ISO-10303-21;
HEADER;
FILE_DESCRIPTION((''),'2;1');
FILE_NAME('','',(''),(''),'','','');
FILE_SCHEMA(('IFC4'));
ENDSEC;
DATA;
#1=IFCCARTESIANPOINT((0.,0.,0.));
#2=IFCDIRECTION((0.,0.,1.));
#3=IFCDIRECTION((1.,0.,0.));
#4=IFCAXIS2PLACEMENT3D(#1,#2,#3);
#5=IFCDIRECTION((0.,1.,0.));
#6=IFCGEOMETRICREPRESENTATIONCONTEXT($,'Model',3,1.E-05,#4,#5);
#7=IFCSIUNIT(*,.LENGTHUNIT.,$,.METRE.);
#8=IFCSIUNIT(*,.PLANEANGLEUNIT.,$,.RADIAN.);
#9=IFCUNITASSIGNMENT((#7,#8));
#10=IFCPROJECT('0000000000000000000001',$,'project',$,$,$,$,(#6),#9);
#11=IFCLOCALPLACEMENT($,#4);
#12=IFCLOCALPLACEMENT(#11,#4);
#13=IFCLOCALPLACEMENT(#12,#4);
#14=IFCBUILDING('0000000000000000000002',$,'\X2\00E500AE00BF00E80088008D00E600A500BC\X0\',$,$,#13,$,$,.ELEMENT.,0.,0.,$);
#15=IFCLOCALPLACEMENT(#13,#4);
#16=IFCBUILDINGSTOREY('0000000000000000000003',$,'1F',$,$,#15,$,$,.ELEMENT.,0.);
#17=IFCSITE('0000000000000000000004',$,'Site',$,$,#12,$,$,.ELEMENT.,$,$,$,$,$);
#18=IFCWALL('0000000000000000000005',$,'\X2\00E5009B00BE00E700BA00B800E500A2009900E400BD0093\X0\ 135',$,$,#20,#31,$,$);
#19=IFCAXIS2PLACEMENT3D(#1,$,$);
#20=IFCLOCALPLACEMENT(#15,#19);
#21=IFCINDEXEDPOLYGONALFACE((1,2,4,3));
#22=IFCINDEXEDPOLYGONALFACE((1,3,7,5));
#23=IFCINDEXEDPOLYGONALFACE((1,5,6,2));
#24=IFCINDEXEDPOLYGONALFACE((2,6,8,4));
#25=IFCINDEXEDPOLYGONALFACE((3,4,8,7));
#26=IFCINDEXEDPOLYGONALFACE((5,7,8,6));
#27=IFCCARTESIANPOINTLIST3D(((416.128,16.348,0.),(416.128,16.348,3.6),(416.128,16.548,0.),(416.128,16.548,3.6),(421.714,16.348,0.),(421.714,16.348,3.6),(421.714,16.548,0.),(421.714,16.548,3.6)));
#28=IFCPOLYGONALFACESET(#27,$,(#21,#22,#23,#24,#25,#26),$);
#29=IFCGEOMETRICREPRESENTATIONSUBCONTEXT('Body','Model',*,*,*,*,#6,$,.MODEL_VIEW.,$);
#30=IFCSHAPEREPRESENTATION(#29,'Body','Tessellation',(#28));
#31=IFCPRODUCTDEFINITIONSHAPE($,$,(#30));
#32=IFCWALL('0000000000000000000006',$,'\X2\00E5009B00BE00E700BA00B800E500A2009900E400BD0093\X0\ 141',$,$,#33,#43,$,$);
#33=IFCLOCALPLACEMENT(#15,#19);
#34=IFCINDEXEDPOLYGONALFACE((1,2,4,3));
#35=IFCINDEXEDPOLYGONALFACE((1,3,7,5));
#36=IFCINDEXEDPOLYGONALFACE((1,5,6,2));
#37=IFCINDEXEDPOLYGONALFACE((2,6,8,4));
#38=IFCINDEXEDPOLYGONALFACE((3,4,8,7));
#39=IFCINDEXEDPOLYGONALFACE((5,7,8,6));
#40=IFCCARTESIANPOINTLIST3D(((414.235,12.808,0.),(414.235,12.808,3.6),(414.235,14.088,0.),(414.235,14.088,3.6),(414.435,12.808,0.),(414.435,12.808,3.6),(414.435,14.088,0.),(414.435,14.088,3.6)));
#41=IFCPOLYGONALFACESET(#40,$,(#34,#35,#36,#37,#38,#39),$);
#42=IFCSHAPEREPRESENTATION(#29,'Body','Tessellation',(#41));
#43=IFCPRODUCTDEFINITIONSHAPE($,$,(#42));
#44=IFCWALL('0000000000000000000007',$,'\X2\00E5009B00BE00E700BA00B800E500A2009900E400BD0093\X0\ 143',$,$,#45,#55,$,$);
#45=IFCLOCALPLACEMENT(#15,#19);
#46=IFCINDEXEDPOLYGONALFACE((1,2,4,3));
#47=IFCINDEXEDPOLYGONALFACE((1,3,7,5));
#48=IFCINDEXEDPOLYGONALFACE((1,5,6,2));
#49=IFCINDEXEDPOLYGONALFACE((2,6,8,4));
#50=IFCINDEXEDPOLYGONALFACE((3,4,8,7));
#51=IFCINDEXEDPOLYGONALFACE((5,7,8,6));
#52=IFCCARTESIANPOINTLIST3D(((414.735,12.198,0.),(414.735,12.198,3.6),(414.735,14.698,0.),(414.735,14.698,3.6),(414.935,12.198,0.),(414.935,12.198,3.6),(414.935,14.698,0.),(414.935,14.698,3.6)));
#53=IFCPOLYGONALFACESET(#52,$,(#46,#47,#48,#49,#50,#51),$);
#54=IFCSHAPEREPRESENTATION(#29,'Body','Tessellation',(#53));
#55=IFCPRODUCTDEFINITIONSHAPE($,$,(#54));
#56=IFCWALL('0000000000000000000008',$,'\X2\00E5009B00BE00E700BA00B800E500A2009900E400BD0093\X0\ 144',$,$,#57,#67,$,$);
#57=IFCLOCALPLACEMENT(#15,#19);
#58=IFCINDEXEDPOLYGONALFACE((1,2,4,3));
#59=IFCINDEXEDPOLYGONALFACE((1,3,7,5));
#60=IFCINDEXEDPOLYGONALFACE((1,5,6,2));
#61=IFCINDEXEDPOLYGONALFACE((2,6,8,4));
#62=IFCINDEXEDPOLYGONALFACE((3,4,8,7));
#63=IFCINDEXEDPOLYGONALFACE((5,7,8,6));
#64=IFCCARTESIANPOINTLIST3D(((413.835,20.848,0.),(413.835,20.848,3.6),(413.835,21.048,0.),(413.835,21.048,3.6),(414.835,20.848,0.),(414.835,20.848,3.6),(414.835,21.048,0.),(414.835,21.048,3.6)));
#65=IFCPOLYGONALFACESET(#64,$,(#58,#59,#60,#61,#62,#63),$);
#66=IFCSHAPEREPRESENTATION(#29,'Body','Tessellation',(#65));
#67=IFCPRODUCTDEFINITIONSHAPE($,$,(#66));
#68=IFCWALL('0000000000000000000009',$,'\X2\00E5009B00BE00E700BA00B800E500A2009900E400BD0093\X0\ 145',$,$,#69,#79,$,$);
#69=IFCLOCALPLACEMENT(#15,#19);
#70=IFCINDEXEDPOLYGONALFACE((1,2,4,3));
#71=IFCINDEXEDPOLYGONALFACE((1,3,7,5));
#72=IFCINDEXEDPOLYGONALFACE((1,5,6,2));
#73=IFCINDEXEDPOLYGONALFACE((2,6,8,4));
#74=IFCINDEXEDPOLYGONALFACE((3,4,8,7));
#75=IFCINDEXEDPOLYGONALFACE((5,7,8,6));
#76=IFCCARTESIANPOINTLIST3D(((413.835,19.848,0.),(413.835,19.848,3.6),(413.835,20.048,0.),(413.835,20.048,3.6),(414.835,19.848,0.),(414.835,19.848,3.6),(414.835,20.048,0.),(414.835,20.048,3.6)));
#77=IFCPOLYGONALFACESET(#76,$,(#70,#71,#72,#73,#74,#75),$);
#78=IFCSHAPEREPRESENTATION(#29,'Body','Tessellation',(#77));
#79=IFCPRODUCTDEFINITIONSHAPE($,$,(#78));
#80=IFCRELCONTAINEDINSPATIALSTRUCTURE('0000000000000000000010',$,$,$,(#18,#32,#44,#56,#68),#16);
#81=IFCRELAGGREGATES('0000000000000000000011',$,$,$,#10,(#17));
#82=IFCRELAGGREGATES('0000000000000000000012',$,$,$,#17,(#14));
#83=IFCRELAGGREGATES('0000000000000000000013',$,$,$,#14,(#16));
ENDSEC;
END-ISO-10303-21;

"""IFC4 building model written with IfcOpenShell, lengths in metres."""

from ifc_helpers import new_model, si_unit, direction, frame, frame_2d, origin_with_axes, place, context, subcontext, project, spatial, rectangle, extrude, element, save


model = new_model("IFC4")

# Units and contexts
model_context = context("Model", 3, precision=1e-05, world=origin_with_axes(), true_north=direction((0.0, 1.0, 0.0)))
body_context = subcontext(model_context, "Body", "Model", "MODEL_VIEW")
ifc_project = project(units=[si_unit("LENGTHUNIT", "METRE"), si_unit("PLANEANGLEUNIT", "RADIAN")], contexts=[model_context])

# Site, building, storey
placement = place(None, origin_with_axes())
site_placement = place(placement, origin_with_axes())
site = spatial("IfcSite", under=ifc_project, at=site_placement, Name="Site", CompositionType="ELEMENT")
building_placement = place(site_placement, origin_with_axes())
building = spatial("IfcBuilding", under=site, at=building_placement, Name="å®¿è\u0088\u008dæ¥¼", CompositionType="ELEMENT", ElevationOfRefHeight=0.0, ElevationOfTerrain=0.0)
storey_placement = place(building_placement, origin_with_axes())
storey = spatial("IfcBuildingStorey", under=building, at=storey_placement, Name="1F", CompositionType="ELEMENT", Elevation=0.0)

# Walls
wall_1_placement = place(storey_placement, frame((418.921, 16.448, 0.0), z_axis=(0.0, 0.0, 1.0), x_axis=(-1.0, 0.0, 0.0)))
element("IfcWall", 1, at=wall_1_placement, inside=storey, Name="å\u009b¾çº¸å¢\u0099ä½\u0093 135", context=body_context, shape_type="SweptSolid", body=[
    extrude(rectangle(XDim=5.586, YDim=0.2, at=frame_2d((0.0, 0.0), x_axis=(1.0, 0.0, 0.0))), frame((0.0, 0.0, 0.0), z_axis=(0.0, 0.0, 1.0)), (0.0, 0.0, 1.0), 3.6),
])
wall_2_placement = place(storey_placement, frame((414.335, 13.448, 0.0), z_axis=(0.0, 0.0, 1.0), x_axis=(0.0, -1.0, 0.0)))
element("IfcWall", 2, at=wall_2_placement, inside=storey, Name="å\u009b¾çº¸å¢\u0099ä½\u0093 141", context=body_context, shape_type="SweptSolid", body=[
    extrude(rectangle(XDim=1.28, YDim=0.2, at=frame_2d((0.0, 0.0), x_axis=(1.0, 0.0, 0.0))), frame((0.0, 0.0, 0.0), z_axis=(0.0, 0.0, 1.0)), (0.0, 0.0, 1.0), 3.6),
])
wall_3_placement = place(storey_placement, frame((414.835, 13.448, 0.0), z_axis=(0.0, 0.0, 1.0), x_axis=(0.0, 1.0, 0.0)))
element("IfcWall", 3, at=wall_3_placement, inside=storey, Name="å\u009b¾çº¸å¢\u0099ä½\u0093 143", context=body_context, shape_type="SweptSolid", body=[
    extrude(rectangle(XDim=2.5, YDim=0.2, at=frame_2d((0.0, 0.0), x_axis=(1.0, 0.0, 0.0))), frame((0.0, 0.0, 0.0), z_axis=(0.0, 0.0, 1.0)), (0.0, 0.0, 1.0), 3.6),
])
for number, where, z_axis, x_axis, name in (
    (4, (414.335, 20.948, 0.0), (0.0, 0.0, 1.0), (-1.0, 0.0, 0.0), "å\u009b¾çº¸å¢\u0099ä½\u0093 144"),
    (5, (414.335, 19.948, 0.0), (0.0, 0.0, 1.0), (-1.0, 0.0, 0.0), "å\u009b¾çº¸å¢\u0099ä½\u0093 145"),
):
    element("IfcWall", number, at=place(storey_placement, frame(where, z_axis=z_axis, x_axis=x_axis)), inside=storey, Name=name, context=body_context, shape_type="SweptSolid", body=[
        extrude(rectangle(XDim=1.0, YDim=0.2, at=frame_2d((0.0, 0.0), x_axis=(1.0, 0.0, 0.0))), frame((0.0, 0.0, 0.0), z_axis=(0.0, 0.0, 1.0)), (0.0, 0.0, 1.0), 3.6),
    ])

save(model, "model.ifc")
